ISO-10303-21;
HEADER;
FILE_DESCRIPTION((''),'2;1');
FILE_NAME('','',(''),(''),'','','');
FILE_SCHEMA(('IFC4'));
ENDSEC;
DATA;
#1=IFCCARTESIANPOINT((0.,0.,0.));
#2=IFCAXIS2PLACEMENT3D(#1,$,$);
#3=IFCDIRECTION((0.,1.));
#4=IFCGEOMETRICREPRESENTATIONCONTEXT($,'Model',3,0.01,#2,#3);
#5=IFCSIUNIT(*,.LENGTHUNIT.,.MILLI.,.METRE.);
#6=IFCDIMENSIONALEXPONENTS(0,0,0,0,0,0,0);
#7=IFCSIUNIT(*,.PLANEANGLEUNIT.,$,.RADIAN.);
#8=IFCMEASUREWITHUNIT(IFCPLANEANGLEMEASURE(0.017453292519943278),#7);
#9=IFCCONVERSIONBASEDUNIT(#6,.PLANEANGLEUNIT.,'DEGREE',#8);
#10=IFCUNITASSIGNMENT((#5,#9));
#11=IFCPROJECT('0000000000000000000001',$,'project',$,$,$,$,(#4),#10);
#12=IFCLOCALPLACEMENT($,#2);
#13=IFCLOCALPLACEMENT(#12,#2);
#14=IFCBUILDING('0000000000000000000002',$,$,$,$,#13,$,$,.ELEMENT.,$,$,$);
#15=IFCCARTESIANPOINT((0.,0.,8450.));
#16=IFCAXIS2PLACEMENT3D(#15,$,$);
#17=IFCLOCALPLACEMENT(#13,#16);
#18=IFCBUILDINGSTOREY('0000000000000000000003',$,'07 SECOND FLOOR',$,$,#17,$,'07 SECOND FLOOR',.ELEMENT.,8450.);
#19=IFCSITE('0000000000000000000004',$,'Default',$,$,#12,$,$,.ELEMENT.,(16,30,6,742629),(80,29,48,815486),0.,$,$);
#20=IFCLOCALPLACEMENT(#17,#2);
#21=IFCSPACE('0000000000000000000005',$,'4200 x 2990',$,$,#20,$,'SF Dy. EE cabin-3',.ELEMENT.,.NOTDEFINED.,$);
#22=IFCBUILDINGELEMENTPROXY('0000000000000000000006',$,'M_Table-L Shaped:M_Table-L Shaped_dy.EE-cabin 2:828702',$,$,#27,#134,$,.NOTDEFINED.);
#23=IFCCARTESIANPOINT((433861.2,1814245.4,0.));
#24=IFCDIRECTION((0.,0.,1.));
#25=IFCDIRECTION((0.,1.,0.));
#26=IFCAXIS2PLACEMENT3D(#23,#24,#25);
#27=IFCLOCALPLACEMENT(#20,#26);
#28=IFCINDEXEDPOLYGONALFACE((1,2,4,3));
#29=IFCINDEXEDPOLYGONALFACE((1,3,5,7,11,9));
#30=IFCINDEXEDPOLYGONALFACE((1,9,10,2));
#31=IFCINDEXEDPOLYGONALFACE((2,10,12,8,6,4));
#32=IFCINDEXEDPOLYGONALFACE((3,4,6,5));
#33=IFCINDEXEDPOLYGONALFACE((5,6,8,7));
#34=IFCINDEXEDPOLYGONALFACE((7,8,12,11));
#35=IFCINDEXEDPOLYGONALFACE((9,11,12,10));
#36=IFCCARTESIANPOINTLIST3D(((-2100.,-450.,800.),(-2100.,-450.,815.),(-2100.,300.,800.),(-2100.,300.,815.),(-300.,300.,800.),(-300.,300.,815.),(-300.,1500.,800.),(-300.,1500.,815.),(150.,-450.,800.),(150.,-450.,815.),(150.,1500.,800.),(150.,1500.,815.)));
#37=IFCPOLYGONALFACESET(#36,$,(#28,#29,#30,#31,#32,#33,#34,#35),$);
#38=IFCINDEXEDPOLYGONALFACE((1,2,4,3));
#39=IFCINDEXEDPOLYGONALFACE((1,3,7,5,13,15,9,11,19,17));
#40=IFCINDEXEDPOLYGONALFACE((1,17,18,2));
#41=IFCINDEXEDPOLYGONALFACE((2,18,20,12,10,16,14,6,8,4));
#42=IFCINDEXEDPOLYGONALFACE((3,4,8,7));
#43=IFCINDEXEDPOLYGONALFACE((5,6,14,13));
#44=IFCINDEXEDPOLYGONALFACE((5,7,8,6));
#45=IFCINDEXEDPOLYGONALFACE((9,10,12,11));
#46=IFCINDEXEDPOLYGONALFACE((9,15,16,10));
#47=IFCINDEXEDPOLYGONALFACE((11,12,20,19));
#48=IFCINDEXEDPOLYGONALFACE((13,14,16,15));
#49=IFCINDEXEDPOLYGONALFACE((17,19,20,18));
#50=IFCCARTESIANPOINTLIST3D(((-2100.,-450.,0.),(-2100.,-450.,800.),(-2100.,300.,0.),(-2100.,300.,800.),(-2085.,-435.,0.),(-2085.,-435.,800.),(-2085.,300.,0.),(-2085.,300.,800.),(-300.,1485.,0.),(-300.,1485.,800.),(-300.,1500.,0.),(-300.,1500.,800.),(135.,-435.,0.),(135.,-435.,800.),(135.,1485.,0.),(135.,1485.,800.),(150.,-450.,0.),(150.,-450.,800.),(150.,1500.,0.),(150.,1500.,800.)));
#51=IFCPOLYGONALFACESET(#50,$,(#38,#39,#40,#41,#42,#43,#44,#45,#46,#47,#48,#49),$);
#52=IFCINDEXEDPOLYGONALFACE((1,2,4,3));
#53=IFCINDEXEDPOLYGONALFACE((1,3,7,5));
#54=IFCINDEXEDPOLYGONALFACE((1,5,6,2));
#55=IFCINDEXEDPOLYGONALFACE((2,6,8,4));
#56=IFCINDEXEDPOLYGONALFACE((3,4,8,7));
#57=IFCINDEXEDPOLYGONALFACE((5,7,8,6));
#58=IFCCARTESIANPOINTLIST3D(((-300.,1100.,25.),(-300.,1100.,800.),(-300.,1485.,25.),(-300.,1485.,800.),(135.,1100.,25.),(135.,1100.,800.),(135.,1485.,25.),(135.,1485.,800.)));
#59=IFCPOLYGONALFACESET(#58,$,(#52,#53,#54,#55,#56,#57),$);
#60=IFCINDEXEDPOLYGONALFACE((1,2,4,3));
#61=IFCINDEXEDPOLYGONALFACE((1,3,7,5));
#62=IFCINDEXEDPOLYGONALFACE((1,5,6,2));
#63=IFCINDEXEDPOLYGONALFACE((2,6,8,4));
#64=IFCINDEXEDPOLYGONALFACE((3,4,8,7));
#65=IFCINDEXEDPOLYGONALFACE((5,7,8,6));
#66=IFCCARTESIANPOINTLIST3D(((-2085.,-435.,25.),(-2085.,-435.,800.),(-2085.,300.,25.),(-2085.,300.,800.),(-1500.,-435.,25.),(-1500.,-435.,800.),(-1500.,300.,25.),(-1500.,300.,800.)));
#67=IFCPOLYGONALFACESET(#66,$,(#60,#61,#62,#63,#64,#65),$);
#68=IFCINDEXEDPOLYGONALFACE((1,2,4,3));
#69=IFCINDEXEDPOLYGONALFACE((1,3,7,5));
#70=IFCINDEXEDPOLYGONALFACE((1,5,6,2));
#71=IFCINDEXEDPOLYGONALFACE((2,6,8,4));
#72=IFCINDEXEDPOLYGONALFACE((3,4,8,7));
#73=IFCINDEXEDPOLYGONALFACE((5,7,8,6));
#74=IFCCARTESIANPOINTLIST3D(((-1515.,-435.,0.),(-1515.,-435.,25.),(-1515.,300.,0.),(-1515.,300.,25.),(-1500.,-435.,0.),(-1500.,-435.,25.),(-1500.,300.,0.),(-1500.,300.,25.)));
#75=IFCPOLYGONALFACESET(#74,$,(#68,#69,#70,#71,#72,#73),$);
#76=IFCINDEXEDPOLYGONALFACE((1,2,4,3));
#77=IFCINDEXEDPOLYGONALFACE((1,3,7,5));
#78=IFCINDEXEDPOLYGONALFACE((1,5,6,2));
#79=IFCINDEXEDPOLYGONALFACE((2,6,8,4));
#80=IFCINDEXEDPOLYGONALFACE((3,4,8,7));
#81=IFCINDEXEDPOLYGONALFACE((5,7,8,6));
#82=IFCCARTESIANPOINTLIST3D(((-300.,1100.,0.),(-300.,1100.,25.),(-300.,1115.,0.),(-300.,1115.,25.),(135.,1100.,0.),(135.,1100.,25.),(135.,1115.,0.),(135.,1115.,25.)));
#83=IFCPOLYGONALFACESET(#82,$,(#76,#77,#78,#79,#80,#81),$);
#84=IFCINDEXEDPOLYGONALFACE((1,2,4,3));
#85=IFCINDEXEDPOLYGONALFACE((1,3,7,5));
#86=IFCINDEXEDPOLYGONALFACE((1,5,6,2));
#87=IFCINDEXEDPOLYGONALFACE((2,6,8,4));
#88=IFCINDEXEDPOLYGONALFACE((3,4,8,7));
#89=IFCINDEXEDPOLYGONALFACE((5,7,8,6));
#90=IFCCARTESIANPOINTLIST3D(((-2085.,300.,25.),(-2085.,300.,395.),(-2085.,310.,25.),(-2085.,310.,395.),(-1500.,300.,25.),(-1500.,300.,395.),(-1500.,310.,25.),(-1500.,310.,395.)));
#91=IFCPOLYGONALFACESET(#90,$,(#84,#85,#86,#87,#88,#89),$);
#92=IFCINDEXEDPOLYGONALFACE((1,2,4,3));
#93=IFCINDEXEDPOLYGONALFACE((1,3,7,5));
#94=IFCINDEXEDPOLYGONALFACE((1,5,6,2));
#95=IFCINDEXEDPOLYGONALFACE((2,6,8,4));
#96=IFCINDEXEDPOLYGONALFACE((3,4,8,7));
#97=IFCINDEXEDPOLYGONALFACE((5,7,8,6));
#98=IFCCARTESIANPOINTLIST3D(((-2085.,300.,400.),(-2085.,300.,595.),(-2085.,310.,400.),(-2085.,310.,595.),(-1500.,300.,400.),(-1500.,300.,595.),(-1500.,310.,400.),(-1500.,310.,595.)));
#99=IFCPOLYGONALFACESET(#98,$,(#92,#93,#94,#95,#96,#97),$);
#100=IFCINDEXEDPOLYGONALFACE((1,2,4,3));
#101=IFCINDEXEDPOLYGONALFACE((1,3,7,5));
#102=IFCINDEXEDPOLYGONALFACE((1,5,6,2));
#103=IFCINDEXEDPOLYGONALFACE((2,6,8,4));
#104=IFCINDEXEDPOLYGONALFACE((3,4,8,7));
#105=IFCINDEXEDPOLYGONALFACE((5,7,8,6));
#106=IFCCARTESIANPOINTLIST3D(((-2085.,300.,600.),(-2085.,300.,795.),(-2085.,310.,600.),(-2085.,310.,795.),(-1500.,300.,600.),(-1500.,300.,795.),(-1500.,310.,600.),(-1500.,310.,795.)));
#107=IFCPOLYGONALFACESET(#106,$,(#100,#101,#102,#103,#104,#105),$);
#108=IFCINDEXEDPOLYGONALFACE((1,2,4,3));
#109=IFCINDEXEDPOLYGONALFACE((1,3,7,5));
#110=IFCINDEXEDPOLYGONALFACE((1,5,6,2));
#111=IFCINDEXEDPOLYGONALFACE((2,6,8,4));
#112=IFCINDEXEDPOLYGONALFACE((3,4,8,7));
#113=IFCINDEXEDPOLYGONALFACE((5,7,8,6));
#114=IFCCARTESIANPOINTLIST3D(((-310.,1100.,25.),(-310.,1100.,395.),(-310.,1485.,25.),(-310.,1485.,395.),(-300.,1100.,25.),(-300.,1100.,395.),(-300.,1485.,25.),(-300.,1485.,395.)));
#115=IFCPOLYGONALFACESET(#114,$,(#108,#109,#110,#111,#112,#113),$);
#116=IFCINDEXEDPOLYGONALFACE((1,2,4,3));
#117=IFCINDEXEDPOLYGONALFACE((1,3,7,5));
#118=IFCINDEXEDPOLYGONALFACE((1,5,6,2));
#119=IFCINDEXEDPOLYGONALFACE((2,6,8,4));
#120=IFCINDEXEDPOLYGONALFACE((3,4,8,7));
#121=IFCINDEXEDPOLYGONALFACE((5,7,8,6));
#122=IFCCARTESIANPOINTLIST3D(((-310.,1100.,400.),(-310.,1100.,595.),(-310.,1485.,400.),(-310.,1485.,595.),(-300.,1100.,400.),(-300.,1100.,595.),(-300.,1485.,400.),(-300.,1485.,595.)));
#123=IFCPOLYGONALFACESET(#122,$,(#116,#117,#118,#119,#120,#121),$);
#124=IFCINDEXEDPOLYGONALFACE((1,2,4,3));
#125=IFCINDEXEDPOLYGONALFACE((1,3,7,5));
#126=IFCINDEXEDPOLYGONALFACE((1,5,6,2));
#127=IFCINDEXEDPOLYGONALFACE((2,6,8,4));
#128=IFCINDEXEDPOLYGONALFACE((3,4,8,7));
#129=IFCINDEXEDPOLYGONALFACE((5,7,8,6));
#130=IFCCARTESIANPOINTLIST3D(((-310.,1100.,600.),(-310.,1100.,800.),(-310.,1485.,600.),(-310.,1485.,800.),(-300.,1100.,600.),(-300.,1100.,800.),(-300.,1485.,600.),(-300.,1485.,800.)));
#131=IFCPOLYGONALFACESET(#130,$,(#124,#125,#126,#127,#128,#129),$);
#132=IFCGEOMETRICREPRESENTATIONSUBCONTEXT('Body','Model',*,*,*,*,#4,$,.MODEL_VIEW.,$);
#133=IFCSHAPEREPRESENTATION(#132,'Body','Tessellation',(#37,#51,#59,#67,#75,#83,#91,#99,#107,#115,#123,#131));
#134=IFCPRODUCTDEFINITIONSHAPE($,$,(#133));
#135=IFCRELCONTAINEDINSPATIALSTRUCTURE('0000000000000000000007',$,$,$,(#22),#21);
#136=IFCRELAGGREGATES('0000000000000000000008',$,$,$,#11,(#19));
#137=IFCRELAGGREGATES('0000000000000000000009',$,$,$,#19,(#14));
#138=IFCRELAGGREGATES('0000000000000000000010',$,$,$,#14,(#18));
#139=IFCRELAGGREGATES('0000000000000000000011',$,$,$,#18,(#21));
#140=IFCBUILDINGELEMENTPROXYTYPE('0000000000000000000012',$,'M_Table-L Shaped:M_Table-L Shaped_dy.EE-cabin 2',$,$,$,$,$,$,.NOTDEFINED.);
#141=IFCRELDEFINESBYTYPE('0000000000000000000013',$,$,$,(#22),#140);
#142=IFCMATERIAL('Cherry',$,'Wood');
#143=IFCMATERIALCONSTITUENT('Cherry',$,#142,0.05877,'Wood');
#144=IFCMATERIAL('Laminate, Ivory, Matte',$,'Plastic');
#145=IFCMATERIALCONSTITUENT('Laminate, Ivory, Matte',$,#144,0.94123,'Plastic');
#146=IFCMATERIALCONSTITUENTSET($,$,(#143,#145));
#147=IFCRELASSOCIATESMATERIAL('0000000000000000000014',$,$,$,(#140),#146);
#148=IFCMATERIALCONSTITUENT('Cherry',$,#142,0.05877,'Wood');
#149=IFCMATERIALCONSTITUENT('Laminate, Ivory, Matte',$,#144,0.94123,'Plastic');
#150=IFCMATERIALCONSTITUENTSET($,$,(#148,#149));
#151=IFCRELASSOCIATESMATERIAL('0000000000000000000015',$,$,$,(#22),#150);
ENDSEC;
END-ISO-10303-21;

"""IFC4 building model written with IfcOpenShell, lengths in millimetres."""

from ifc_helpers import new_model, entity, si_unit, converted_unit, direction, frame, origin, place, context, subcontext, project, spatial, indexed_curve, outline, extrude, source, transform, mapped, material, constituent, constituent_set, type_object, type_shapes, element, save


model = new_model("IFC4")

# Units and contexts
model_context = context("Model", 3, precision=0.01, world=origin(), true_north=direction((0.0, 1.0)))
body_context = subcontext(model_context, "Body", "Model", "MODEL_VIEW")
ifc_project = project(units=[si_unit("LENGTHUNIT", "METRE", prefix="MILLI"), converted_unit("PLANEANGLEUNIT", "DEGREE", entity("IfcPlaneAngleMeasure", 0.017453292519943278), si_unit("PLANEANGLEUNIT", "RADIAN"), dimensions=[0, 0, 0, 0, 0, 0, 0])], contexts=[model_context])

# Site, building, storey
site_placement = place(None, origin())
site = spatial("IfcSite", under=ifc_project, at=site_placement, Name="Default", CompositionType="ELEMENT", RefLatitude=(16, 30, 6, 742629), RefLongitude=(80, 29, 48, 815486), RefElevation=0.0)
building_placement = place(site_placement, origin())
building = spatial("IfcBuilding", under=site, at=building_placement, CompositionType="ELEMENT")
storey_placement = place(building_placement, frame((0.0, 0.0, 8450.0)))
storey = spatial("IfcBuildingStorey", under=building, at=storey_placement, Name="07 SECOND FLOOR", LongName="07 SECOND FLOOR", CompositionType="ELEMENT", Elevation=8450.0)

# Shared definitions
space_1_placement = place(storey_placement, origin())
space_1 = spatial("IfcSpace", under=storey, at=space_1_placement, Name="4200 x 2990", LongName="SF Dy. EE cabin-3", CompositionType="ELEMENT", PredefinedType="NOTDEFINED")

# Building element proxy
ifc_material_1 = material(Name="Cherry", Category="Wood")
ifc_constituent_1 = constituent(ifc_material_1, Name="Cherry", Category="Wood", fraction=0.05877)
ifc_material_2 = material(Name="Laminate, Ivory, Matte", Category="Plastic")
ifc_constituent_2 = constituent(ifc_material_2, Name="Laminate, Ivory, Matte", Category="Plastic", fraction=0.94123)
ifc_constituent_set_1 = constituent_set(constituents=[ifc_constituent_1, ifc_constituent_2])
ifc_constituent_3 = constituent(ifc_material_1, Name="Cherry", Category="Wood", fraction=0.05877)
ifc_constituent_4 = constituent(ifc_material_2, Name="Laminate, Ivory, Matte", Category="Plastic", fraction=0.94123)
ifc_constituent_set_2 = constituent_set(constituents=[ifc_constituent_3, ifc_constituent_4])
building_element_proxy_type_1 = type_object("IfcBuildingElementProxyType", Name="M_Table-L Shaped:M_Table-L Shaped_dy.EE-cabin 2", PredefinedType="NOTDEFINED", material=ifc_constituent_set_2)
shared_shape_1 = source(origin(), body_context, "Body", "SweptSolid", [
    extrude(outline(indexed_curve([(-1050.0, -450.0), (-1050.0, -900.0), (900.0, -900.0), (900.0, 1350.0), (150.0, 1350.0), (150.0, -450.0), (-1050.0, -450.0)], self_intersect=False)), frame((-750.0, 450.0, 800.0), z_axis=(0.0, 0.0, -1.0), x_axis=(0.0, -1.0, 0.0)), (0.0, 0.0, -1.0), 15.0),
    extrude(outline(indexed_curve([(-1020.0, 540.0), (-1005.0, 540.0), (-1005.0, 975.0), (915.0, 975.0), (915.0, -1245.0), (180.0, -1245.0), (180.0, -1260.0), (930.0, -1260.0), (930.0, 990.0), (-1020.0, 990.0), (-1020.0, 540.0)], self_intersect=False)), frame((-840.0, 480.0, 0.0), z_axis=(0.0, 0.0, 1.0), x_axis=(0.0, -1.0, 0.0)), (0.0, 0.0, 1.0), 800.0),
    extrude(outline(indexed_curve([(-217.5, -192.5), (217.5, -192.5), (217.5, 192.5), (-217.5, 192.5), (-217.5, -192.5)], self_intersect=False)), frame((-82.5, 1292.5, 25.0), z_axis=(0.0, 0.0, 1.0), x_axis=(-1.0, 0.0, 0.0)), (0.0, 0.0, 1.0), 775.0),
    extrude(outline(indexed_curve([(-367.5, -292.5), (367.5, -292.5), (367.5, 292.5), (-367.5, 292.5), (-367.5, -292.5)], self_intersect=False)), frame((-1792.5, -67.5, 25.0), z_axis=(0.0, 0.0, 1.0), x_axis=(0.0, -1.0, 0.0)), (0.0, 0.0, 1.0), 775.0),
    extrude(outline(indexed_curve([(-7.5, -367.5), (7.5, -367.5), (7.5, 367.5), (-7.5, 367.5), (-7.5, -367.5)], self_intersect=False)), frame((-1507.5, -67.5, 0.0), z_axis=(0.0, 0.0, 1.0), x_axis=(-1.0, 0.0, 0.0)), (0.0, 0.0, 1.0), 25.0),
    extrude(outline(indexed_curve([(-7.5, -217.5), (7.5, -217.5), (7.5, 217.5), (-7.5, 217.5), (-7.5, -217.5)], self_intersect=False)), frame((-82.5, 1107.5, 0.0), z_axis=(0.0, 0.0, 1.0), x_axis=(0.0, 1.0, 0.0)), (0.0, 0.0, 1.0), 25.0),
    extrude(outline(indexed_curve([(-5.0, -292.5), (5.0, -292.5), (5.0, 292.5), (-5.0, 292.5), (-5.0, -292.5)], self_intersect=False)), frame((-1792.5, 305.0, 25.0), z_axis=(0.0, 0.0, 1.0), x_axis=(0.0, 1.0, 0.0)), (0.0, 0.0, 1.0), 370.0),
    extrude(outline(indexed_curve([(-5.0, -292.5), (5.0, -292.5), (5.0, 292.5), (-5.0, 292.5), (-5.0, -292.5)], self_intersect=False)), frame((-1792.5, 305.0, 400.0), z_axis=(0.0, 0.0, 1.0), x_axis=(0.0, 1.0, 0.0)), (0.0, 0.0, 1.0), 195.0),
    extrude(outline(indexed_curve([(-5.0, -292.5), (5.0, -292.5), (5.0, 292.5), (-5.0, 292.5), (-5.0, -292.5)], self_intersect=False)), frame((-1792.5, 305.0, 600.0), z_axis=(0.0, 0.0, 1.0), x_axis=(0.0, 1.0, 0.0)), (0.0, 0.0, 1.0), 195.0),
    extrude(outline(indexed_curve([(-192.5, -5.0), (192.5, -5.0), (192.5, 5.0), (-192.5, 5.0), (-192.5, -5.0)], self_intersect=False)), frame((-305.0, 1292.5, 25.0), z_axis=(0.0, 0.0, 1.0), x_axis=(0.0, -1.0, 0.0)), (0.0, 0.0, 1.0), 370.0),
    extrude(outline(indexed_curve([(-192.5, -5.0), (192.5, -5.0), (192.5, 5.0), (-192.5, 5.0), (-192.5, -5.0)], self_intersect=False)), frame((-305.0, 1292.5, 400.0), z_axis=(0.0, 0.0, 1.0), x_axis=(0.0, -1.0, 0.0)), (0.0, 0.0, 1.0), 195.0),
    extrude(outline(indexed_curve([(-192.5, -5.0), (192.5, -5.0), (192.5, 5.0), (-192.5, 5.0), (-192.5, -5.0)], self_intersect=False)), frame((-305.0, 1292.5, 600.0), z_axis=(0.0, 0.0, 1.0), x_axis=(0.0, -1.0, 0.0)), (0.0, 0.0, 1.0), 200.0),
])
type_shapes(building_element_proxy_type_1, [shared_shape_1])
proxy_1_placement = place(space_1_placement, frame((433861.2, 1814245.4, 0.0), z_axis=(0.0, 0.0, 1.0), x_axis=(0.0, 1.0, 0.0)))
element("IfcBuildingElementProxy", 1, at=proxy_1_placement, inside=space_1, type_object=building_element_proxy_type_1, material=ifc_constituent_set_1, Name="M_Table-L Shaped:M_Table-L Shaped_dy.EE-cabin 2:828702", PredefinedType="NOTDEFINED", context=body_context, shape_type="MappedRepresentation", body=[
    mapped(shared_shape_1, transform((0.0, 0.0, 0.0), scale=1.0)),
])

save(model, "model.ifc")
